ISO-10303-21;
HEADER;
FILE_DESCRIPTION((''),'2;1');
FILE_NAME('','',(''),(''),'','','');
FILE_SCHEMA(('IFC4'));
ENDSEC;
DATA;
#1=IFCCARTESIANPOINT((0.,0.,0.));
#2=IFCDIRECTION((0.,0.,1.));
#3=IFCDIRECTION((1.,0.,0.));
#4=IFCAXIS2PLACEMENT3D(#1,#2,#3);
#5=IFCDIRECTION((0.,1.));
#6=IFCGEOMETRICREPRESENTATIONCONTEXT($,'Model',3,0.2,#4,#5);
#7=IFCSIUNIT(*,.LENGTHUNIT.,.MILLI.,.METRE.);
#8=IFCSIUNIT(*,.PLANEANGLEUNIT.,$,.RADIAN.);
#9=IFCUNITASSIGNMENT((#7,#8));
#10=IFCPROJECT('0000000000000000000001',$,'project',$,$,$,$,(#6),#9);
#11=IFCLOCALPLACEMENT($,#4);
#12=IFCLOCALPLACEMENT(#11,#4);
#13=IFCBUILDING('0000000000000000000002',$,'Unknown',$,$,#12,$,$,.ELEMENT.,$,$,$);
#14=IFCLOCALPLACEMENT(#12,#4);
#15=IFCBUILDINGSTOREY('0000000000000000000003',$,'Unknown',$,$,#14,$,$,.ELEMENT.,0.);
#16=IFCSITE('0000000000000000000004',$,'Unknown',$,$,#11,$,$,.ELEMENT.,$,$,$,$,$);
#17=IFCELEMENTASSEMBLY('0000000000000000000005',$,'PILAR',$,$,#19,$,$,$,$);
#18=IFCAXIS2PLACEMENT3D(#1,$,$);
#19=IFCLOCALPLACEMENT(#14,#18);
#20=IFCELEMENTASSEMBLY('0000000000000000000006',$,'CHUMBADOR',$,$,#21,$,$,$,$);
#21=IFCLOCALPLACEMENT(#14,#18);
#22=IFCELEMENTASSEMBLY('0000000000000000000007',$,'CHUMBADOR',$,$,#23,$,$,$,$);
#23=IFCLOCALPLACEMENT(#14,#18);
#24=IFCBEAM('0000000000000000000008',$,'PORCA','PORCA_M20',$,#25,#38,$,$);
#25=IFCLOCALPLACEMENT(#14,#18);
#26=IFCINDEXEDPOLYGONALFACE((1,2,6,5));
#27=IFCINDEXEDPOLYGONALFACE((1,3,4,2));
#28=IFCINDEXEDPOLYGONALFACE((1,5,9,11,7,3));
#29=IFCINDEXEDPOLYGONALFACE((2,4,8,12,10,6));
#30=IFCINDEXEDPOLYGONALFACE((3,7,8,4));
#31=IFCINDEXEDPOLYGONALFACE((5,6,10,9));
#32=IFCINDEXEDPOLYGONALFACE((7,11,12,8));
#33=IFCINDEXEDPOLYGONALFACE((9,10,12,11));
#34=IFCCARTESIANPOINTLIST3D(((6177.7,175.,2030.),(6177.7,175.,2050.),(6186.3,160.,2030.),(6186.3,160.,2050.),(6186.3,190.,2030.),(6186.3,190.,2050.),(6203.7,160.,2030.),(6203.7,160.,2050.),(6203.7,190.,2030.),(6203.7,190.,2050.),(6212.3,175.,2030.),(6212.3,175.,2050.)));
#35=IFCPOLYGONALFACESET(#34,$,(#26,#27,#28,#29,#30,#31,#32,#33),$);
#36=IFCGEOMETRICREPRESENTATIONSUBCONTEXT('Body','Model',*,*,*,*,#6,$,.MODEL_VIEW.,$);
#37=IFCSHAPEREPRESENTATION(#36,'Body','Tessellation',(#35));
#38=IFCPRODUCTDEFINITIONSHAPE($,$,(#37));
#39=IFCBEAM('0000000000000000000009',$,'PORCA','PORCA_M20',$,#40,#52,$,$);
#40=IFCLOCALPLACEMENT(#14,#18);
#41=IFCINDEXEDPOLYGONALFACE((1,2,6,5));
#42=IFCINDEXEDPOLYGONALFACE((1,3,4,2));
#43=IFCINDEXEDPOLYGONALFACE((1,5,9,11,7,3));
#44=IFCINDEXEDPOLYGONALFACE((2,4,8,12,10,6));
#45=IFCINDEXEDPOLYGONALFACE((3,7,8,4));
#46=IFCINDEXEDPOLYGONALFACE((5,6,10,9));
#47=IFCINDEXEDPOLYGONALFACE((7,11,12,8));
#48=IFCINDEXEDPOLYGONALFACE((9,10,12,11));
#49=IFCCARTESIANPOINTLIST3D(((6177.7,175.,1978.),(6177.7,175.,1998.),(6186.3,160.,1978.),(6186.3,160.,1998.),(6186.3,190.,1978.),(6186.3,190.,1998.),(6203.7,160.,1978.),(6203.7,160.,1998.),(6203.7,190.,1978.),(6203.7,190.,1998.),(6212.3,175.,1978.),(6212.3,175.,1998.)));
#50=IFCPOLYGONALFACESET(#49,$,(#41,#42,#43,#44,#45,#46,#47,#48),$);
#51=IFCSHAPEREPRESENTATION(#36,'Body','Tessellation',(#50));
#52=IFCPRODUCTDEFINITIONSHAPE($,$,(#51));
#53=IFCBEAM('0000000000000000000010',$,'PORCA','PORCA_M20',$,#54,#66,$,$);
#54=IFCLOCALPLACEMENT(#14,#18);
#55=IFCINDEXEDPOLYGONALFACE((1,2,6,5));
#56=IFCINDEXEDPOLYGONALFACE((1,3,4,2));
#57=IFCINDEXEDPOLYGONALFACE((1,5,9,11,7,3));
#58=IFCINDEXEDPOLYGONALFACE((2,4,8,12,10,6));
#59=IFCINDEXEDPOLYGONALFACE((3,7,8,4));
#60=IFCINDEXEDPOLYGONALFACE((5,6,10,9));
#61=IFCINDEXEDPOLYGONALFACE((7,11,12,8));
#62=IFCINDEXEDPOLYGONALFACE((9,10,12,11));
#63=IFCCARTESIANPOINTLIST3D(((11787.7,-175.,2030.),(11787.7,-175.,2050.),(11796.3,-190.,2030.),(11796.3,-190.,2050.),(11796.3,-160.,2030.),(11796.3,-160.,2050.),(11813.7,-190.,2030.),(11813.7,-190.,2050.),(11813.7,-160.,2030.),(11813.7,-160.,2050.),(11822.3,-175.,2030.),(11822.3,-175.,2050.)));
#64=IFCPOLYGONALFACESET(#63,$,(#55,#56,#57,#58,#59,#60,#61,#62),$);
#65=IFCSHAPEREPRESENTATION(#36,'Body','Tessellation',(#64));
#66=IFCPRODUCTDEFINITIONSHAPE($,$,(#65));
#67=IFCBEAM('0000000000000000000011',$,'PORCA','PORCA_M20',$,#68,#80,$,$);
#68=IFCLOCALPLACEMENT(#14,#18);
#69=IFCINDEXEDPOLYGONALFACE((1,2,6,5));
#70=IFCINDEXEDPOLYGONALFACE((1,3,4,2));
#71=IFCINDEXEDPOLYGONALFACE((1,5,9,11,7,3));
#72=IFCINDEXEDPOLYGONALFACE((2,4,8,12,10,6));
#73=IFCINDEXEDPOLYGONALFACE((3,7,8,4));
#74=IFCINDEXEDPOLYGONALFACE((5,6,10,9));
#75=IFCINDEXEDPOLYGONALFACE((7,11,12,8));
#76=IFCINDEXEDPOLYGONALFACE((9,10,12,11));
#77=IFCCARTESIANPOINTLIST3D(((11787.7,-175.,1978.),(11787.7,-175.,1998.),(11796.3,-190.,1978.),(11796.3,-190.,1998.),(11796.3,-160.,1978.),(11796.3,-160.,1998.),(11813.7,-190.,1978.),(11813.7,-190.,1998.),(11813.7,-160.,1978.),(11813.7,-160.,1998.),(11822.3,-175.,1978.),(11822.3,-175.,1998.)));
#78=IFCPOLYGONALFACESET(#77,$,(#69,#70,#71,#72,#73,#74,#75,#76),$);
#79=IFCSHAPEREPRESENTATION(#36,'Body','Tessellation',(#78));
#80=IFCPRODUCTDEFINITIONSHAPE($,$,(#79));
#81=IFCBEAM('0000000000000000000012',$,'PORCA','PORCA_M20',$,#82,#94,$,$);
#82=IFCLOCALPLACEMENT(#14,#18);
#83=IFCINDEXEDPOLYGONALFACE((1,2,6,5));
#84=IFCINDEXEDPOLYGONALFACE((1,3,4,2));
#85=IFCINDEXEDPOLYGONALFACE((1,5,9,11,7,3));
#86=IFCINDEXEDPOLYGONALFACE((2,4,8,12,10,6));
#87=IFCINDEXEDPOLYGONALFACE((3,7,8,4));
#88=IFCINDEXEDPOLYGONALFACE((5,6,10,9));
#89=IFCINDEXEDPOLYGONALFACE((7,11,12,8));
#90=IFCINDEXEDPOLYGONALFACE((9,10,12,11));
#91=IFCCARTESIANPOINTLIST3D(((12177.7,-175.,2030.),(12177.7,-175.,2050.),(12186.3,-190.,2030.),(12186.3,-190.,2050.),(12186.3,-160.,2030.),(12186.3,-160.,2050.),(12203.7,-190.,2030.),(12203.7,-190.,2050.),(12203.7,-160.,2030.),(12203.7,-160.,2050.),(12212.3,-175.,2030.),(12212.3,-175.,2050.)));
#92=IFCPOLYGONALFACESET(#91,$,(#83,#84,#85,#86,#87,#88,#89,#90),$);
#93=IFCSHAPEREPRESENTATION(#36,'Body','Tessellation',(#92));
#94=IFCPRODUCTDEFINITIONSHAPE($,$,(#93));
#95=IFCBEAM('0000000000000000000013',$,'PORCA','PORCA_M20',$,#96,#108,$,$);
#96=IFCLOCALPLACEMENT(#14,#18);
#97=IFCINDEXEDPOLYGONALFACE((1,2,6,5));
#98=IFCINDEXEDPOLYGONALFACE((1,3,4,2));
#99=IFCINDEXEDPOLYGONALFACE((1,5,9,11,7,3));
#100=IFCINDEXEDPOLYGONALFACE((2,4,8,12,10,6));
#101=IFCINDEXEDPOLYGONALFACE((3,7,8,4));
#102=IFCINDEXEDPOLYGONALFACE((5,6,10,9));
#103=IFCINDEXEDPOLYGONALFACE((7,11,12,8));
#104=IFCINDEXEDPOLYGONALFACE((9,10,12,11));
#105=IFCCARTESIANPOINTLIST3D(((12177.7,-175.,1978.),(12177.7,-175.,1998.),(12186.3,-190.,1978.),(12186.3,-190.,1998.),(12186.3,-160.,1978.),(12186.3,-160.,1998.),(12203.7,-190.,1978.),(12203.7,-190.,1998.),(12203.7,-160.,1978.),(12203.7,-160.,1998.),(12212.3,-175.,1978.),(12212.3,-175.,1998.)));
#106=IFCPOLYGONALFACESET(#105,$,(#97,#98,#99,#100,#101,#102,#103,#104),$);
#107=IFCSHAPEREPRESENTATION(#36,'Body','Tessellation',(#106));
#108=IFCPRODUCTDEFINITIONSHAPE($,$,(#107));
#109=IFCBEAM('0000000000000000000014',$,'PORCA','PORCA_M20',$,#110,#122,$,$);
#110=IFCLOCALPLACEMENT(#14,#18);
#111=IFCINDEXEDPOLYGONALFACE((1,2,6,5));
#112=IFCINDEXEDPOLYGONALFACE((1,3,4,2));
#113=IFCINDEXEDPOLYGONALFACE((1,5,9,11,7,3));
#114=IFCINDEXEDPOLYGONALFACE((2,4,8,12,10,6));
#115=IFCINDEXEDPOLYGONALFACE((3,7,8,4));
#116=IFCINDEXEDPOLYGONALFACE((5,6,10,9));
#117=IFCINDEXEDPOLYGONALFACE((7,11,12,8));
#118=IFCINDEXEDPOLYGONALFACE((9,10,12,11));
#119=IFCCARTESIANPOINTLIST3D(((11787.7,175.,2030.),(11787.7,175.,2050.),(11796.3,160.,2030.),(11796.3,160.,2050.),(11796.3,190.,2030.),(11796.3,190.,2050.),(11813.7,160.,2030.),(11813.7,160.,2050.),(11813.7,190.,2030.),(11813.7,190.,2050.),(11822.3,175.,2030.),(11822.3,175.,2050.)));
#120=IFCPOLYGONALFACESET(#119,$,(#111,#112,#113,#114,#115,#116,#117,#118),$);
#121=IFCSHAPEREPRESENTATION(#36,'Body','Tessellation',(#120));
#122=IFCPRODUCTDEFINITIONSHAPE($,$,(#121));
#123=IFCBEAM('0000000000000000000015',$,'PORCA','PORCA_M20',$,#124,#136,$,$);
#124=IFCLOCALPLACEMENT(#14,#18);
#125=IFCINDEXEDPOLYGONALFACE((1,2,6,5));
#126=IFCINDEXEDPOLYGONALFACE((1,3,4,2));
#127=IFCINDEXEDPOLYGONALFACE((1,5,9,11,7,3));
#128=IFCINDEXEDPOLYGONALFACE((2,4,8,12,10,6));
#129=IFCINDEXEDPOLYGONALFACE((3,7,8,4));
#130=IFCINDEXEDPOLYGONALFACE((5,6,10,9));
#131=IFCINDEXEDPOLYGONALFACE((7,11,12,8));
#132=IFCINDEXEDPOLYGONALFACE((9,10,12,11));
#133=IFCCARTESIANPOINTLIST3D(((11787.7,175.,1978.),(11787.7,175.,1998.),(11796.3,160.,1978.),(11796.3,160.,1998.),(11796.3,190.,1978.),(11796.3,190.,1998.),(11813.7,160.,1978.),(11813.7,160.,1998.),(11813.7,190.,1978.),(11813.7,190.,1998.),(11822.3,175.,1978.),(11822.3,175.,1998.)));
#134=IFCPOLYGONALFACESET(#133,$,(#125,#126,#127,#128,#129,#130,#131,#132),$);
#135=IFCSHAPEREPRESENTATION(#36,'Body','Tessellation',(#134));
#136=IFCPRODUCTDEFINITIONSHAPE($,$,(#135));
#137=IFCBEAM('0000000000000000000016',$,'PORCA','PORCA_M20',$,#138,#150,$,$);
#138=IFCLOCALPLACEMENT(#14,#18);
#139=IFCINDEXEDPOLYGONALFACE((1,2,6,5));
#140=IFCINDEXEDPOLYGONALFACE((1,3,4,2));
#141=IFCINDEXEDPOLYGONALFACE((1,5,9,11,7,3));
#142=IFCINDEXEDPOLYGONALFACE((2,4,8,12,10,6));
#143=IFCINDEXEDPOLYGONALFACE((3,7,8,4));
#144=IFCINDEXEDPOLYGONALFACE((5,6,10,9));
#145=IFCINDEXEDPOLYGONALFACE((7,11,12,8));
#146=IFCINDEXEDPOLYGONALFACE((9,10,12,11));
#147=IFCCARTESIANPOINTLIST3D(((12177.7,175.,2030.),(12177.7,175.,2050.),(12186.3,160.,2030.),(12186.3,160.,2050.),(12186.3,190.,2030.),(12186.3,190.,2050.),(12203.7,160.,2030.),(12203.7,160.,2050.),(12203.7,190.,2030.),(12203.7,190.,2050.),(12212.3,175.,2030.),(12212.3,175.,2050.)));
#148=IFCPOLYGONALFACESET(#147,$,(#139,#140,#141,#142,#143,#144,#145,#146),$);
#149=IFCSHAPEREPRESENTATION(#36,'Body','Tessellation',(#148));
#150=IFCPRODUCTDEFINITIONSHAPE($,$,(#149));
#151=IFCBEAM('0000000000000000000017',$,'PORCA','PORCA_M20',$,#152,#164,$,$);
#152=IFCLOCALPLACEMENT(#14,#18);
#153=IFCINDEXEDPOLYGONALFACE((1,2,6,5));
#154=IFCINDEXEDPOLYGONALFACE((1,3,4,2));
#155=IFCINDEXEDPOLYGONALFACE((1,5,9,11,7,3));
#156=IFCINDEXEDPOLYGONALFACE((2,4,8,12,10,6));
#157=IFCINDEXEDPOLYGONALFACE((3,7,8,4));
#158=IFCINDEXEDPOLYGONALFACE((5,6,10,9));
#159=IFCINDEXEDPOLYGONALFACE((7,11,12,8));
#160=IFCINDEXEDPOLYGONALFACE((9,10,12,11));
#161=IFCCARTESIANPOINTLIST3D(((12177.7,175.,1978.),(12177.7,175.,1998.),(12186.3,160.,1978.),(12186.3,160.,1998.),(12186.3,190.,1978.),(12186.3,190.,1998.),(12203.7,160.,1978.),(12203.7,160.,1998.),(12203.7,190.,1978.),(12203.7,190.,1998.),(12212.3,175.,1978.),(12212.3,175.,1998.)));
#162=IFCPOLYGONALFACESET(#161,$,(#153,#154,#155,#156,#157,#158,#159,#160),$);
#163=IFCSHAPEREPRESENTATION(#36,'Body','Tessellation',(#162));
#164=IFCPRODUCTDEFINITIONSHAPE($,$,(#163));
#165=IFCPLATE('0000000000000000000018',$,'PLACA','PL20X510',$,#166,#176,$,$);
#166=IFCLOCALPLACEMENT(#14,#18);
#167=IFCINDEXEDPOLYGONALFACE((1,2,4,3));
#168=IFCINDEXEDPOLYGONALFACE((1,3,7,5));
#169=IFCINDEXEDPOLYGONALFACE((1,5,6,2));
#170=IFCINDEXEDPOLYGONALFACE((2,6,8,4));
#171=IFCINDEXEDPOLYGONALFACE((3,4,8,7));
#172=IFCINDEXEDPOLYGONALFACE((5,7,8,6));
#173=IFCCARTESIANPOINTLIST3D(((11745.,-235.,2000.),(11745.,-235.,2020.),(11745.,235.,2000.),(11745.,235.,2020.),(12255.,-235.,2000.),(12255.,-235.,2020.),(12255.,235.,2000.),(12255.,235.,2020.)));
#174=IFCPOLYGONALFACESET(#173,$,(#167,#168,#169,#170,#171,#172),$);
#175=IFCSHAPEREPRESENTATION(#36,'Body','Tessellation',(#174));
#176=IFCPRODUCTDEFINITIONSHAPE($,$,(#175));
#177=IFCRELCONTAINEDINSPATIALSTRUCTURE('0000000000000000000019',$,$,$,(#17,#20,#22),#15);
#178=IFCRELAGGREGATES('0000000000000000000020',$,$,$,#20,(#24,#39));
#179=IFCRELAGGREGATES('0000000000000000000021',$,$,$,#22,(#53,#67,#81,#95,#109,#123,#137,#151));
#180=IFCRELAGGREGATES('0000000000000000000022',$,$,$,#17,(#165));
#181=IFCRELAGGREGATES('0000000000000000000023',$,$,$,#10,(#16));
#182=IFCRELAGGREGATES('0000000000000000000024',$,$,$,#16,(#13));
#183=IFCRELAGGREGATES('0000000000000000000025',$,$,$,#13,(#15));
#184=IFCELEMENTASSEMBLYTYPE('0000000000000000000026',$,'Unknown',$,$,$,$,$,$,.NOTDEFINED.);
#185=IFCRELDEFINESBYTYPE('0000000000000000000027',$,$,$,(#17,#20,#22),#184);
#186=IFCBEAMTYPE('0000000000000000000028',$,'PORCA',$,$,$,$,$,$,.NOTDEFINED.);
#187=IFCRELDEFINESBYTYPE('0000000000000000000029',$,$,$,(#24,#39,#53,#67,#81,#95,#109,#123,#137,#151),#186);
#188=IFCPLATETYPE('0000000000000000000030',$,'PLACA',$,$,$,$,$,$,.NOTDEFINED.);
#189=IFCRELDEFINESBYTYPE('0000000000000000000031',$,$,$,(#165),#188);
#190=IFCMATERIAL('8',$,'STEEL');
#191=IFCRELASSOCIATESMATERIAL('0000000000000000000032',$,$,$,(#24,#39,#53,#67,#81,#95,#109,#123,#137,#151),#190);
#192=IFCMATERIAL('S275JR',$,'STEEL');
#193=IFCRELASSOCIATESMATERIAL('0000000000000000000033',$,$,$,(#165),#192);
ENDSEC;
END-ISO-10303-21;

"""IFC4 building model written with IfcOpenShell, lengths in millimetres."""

from ifc_helpers import new_model, si_unit, direction, frame, origin_with_axes, origin_2d_with_axis, place, context, subcontext, project, spatial, polyline, rectangle, outline, extrude, material, material_profile, profile_set, profile_usage, type_object, element, aggregate, save


model = new_model("IFC4")

# Units and contexts
model_context = context("Model", 3, precision=0.2, world=origin_with_axes(), true_north=direction((0.0, 1.0)))
body_context = subcontext(model_context, "Body", "Model", "MODEL_VIEW")
ifc_project = project(units=[si_unit("LENGTHUNIT", "METRE", prefix="MILLI"), si_unit("PLANEANGLEUNIT", "RADIAN")], contexts=[model_context])

# Site, building, storey
site_placement = place(None, origin_with_axes())
site = spatial("IfcSite", under=ifc_project, at=site_placement, Name="Unknown", CompositionType="ELEMENT")
building_placement = place(site_placement, origin_with_axes())
building = spatial("IfcBuilding", under=site, at=building_placement, Name="Unknown", CompositionType="ELEMENT")
storey_placement = place(building_placement, origin_with_axes())
storey = spatial("IfcBuildingStorey", under=building, at=storey_placement, Name="Unknown", CompositionType="ELEMENT", Elevation=0.0)

# Element assembly
element_assembly_type = type_object("IfcElementAssemblyType", Name="Unknown", PredefinedType="NOTDEFINED")
assembly_1_placement = place(storey_placement, frame((12000.0, 0.0, 2000.0), z_axis=(1.0, 0.0, 0.0), x_axis=(0.0, 0.0, 1.0)))
assembly_1 = element("IfcElementAssembly", 1, at=assembly_1_placement, inside=storey, type_object=element_assembly_type, Name="PILAR")

# Element assemblies
assembly_2_placement = place(storey_placement, frame((5805.0, -175.0, 1945.0), z_axis=(1.0, 0.0, 0.0), x_axis=(0.0, 0.0, -1.0)))
assembly_2 = element("IfcElementAssembly", 2, at=assembly_2_placement, inside=storey, type_object=element_assembly_type, Name="CHUMBADOR")
ifc_material_1 = material(Name="S275JR", Category="STEEL")
assembly_3_placement = place(storey_placement, frame((11805.0, -175.0, 1945.0), z_axis=(1.0, 0.0, 0.0), x_axis=(0.0, 0.0, -1.0)))
assembly_3 = element("IfcElementAssembly", 3, at=assembly_3_placement, inside=storey, type_object=element_assembly_type, Name="CHUMBADOR")

# Beams
ifc_material_2 = material(Name="8", Category="STEEL")
ifc_material_profile_1 = material_profile(ifc_material_2, outline(polyline([(8.7, -15.0), (17.3, 0.0), (8.7, 15.0), (-8.7, 15.0), (-17.3, 0.0), (-8.7, -15.0), (8.7, -15.0)])), Name="PORCA_M20")
ifc_profile_set_1 = profile_set([ifc_material_profile_1])
ifc_profile_usage_1 = profile_usage(ifc_profile_set_1, cardinal=5)
beam_type_1 = type_object("IfcBeamType", Name="PORCA", PredefinedType="NOTDEFINED")
beam_1_placement = place(assembly_2_placement, frame((-105.0, 350.0, 390.0), z_axis=(0.0, 0.0, 1.0), x_axis=(1.0, 0.0, 0.0)))
beam_1 = element("IfcBeam", 4, at=beam_1_placement, type_object=beam_type_1, material=ifc_profile_usage_1, Name="PORCA", Description="PORCA_M20", context=body_context, shape_type="SolidModel", body=[
    extrude(outline(polyline([(8.7, -15.0), (17.3, 0.0), (8.7, 15.0), (-8.7, 15.0), (-17.3, 0.0), (-8.7, -15.0), (8.7, -15.0)])), frame((0.0, 0.0, 0.0), z_axis=(-1.0, 0.0, 0.0), x_axis=(0.0, 0.0, 1.0)), (0.0, 0.0, -1.0), 20.0),
])
beam_2_placement = place(assembly_2_placement, frame((-53.0, 350.0, 390.0), z_axis=(0.0, 0.0, 1.0), x_axis=(1.0, 0.0, 0.0)))
beam_2 = element("IfcBeam", 5, at=beam_2_placement, type_object=beam_type_1, material=ifc_profile_usage_1, Name="PORCA", Description="PORCA_M20", context=body_context, shape_type="SolidModel", body=[
    extrude(outline(polyline([(8.7, -15.0), (17.3, 0.0), (8.7, 15.0), (-8.7, 15.0), (-17.3, 0.0), (-8.7, -15.0), (8.7, -15.0)])), frame((0.0, 0.0, 0.0), z_axis=(-1.0, 0.0, 0.0), x_axis=(0.0, 0.0, 1.0)), (0.0, 0.0, -1.0), 20.0),
])
aggregate(assembly_2, [beam_1, beam_2])
beam_3_placement = place(assembly_3_placement, frame((-105.0, 0.0, 0.0), z_axis=(0.0, 0.0, -1.0), x_axis=(1.0, 0.0, 0.0)))
beam_3 = element("IfcBeam", 6, at=beam_3_placement, type_object=beam_type_1, material=ifc_profile_usage_1, Name="PORCA", Description="PORCA_M20", context=body_context, shape_type="SolidModel", body=[
    extrude(outline(polyline([(8.7, -15.0), (17.3, 0.0), (8.7, 15.0), (-8.7, 15.0), (-17.3, 0.0), (-8.7, -15.0), (8.7, -15.0)])), frame((0.0, 0.0, 0.0), z_axis=(-1.0, 0.0, 0.0), x_axis=(0.0, 0.0, 1.0)), (0.0, 0.0, -1.0), 20.0),
])
beam_4_placement = place(assembly_3_placement, frame((-53.0, 0.0, 0.0), z_axis=(0.0, 0.0, -1.0), x_axis=(1.0, 0.0, 0.0)))
beam_4 = element("IfcBeam", 7, at=beam_4_placement, type_object=beam_type_1, material=ifc_profile_usage_1, Name="PORCA", Description="PORCA_M20", context=body_context, shape_type="SolidModel", body=[
    extrude(outline(polyline([(8.7, -15.0), (17.3, 0.0), (8.7, 15.0), (-8.7, 15.0), (-17.3, 0.0), (-8.7, -15.0), (8.7, -15.0)])), frame((0.0, 0.0, 0.0), z_axis=(-1.0, 0.0, 0.0), x_axis=(0.0, 0.0, 1.0)), (0.0, 0.0, -1.0), 20.0),
])
beam_5_placement = place(assembly_3_placement, frame((-105.0, 0.0, 390.0), z_axis=(0.0, 0.0, 1.0), x_axis=(1.0, 0.0, 0.0)))
beam_5 = element("IfcBeam", 8, at=beam_5_placement, type_object=beam_type_1, material=ifc_profile_usage_1, Name="PORCA", Description="PORCA_M20", context=body_context, shape_type="SolidModel", body=[
    extrude(outline(polyline([(8.7, -15.0), (17.3, 0.0), (8.7, 15.0), (-8.7, 15.0), (-17.3, 0.0), (-8.7, -15.0), (8.7, -15.0)])), frame((0.0, 0.0, 0.0), z_axis=(-1.0, 0.0, 0.0), x_axis=(0.0, 0.0, 1.0)), (0.0, 0.0, -1.0), 20.0),
])
beam_6_placement = place(assembly_3_placement, frame((-53.0, 0.0, 390.0), z_axis=(0.0, 0.0, 1.0), x_axis=(1.0, 0.0, 0.0)))
beam_6 = element("IfcBeam", 9, at=beam_6_placement, type_object=beam_type_1, material=ifc_profile_usage_1, Name="PORCA", Description="PORCA_M20", context=body_context, shape_type="SolidModel", body=[
    extrude(outline(polyline([(8.7, -15.0), (17.3, 0.0), (8.7, 15.0), (-8.7, 15.0), (-17.3, 0.0), (-8.7, -15.0), (8.7, -15.0)])), frame((0.0, 0.0, 0.0), z_axis=(-1.0, 0.0, 0.0), x_axis=(0.0, 0.0, 1.0)), (0.0, 0.0, -1.0), 20.0),
])
beam_7_placement = place(assembly_3_placement, frame((-105.0, 350.0, 0.0), z_axis=(0.0, 0.0, -1.0), x_axis=(1.0, 0.0, 0.0)))
beam_7 = element("IfcBeam", 10, at=beam_7_placement, type_object=beam_type_1, material=ifc_profile_usage_1, Name="PORCA", Description="PORCA_M20", context=body_context, shape_type="SolidModel", body=[
    extrude(outline(polyline([(8.7, -15.0), (17.3, 0.0), (8.7, 15.0), (-8.7, 15.0), (-17.3, 0.0), (-8.7, -15.0), (8.7, -15.0)])), frame((0.0, 0.0, 0.0), z_axis=(-1.0, 0.0, 0.0), x_axis=(0.0, 0.0, 1.0)), (0.0, 0.0, -1.0), 20.0),
])
beam_8_placement = place(assembly_3_placement, frame((-53.0, 350.0, 0.0), z_axis=(0.0, 0.0, -1.0), x_axis=(1.0, 0.0, 0.0)))
beam_8 = element("IfcBeam", 11, at=beam_8_placement, type_object=beam_type_1, material=ifc_profile_usage_1, Name="PORCA", Description="PORCA_M20", context=body_context, shape_type="SolidModel", body=[
    extrude(outline(polyline([(8.7, -15.0), (17.3, 0.0), (8.7, 15.0), (-8.7, 15.0), (-17.3, 0.0), (-8.7, -15.0), (8.7, -15.0)])), frame((0.0, 0.0, 0.0), z_axis=(-1.0, 0.0, 0.0), x_axis=(0.0, 0.0, 1.0)), (0.0, 0.0, -1.0), 20.0),
])
beam_9_placement = place(assembly_3_placement, frame((-105.0, 350.0, 390.0), z_axis=(0.0, 0.0, 1.0), x_axis=(1.0, 0.0, 0.0)))
beam_9 = element("IfcBeam", 12, at=beam_9_placement, type_object=beam_type_1, material=ifc_profile_usage_1, Name="PORCA", Description="PORCA_M20", context=body_context, shape_type="SolidModel", body=[
    extrude(outline(polyline([(8.7, -15.0), (17.3, 0.0), (8.7, 15.0), (-8.7, 15.0), (-17.3, 0.0), (-8.7, -15.0), (8.7, -15.0)])), frame((0.0, 0.0, 0.0), z_axis=(-1.0, 0.0, 0.0), x_axis=(0.0, 0.0, 1.0)), (0.0, 0.0, -1.0), 20.0),
])
beam_10_placement = place(assembly_3_placement, frame((-53.0, 350.0, 390.0), z_axis=(0.0, 0.0, 1.0), x_axis=(1.0, 0.0, 0.0)))
beam_10 = element("IfcBeam", 13, at=beam_10_placement, type_object=beam_type_1, material=ifc_profile_usage_1, Name="PORCA", Description="PORCA_M20", context=body_context, shape_type="SolidModel", body=[
    extrude(outline(polyline([(8.7, -15.0), (17.3, 0.0), (8.7, 15.0), (-8.7, 15.0), (-17.3, 0.0), (-8.7, -15.0), (8.7, -15.0)])), frame((0.0, 0.0, 0.0), z_axis=(-1.0, 0.0, 0.0), x_axis=(0.0, 0.0, 1.0)), (0.0, 0.0, -1.0), 20.0),
])
aggregate(assembly_3, [beam_3, beam_4, beam_5, beam_6, beam_7, beam_8, beam_9, beam_10])

# Plate
ifc_material_profile_2 = material_profile(ifc_material_1, rectangle(XDim=470.0, YDim=510.0, at=origin_2d_with_axis()), Name="PL20X510")
ifc_profile_set_2 = profile_set([ifc_material_profile_2])
ifc_profile_usage_2 = profile_usage(ifc_profile_set_2, cardinal=8)
plate_type_1 = type_object("IfcPlateType", Name="PLACA", PredefinedType="NOTDEFINED")
plate_1_placement = place(assembly_1_placement, frame((10.0, 235.0, 0.0), z_axis=(0.0, -1.0, 0.0), x_axis=(1.0, 0.0, 0.0)))
plate_1 = element("IfcPlate", 14, at=plate_1_placement, type_object=plate_type_1, material=ifc_profile_usage_2, Name="PLACA", Description="PL20X510", context=body_context, shape_type="SolidModel", body=[
    extrude(rectangle(XDim=470.0, YDim=510.0, at=origin_2d_with_axis()), frame((-10.0, 0.0, 235.0), z_axis=(-1.0, 0.0, 0.0), x_axis=(0.0, 0.0, 1.0)), (0.0, 0.0, -1.0), 20.0),
])

aggregate(assembly_1, [plate_1])

save(model, "model.ifc")
